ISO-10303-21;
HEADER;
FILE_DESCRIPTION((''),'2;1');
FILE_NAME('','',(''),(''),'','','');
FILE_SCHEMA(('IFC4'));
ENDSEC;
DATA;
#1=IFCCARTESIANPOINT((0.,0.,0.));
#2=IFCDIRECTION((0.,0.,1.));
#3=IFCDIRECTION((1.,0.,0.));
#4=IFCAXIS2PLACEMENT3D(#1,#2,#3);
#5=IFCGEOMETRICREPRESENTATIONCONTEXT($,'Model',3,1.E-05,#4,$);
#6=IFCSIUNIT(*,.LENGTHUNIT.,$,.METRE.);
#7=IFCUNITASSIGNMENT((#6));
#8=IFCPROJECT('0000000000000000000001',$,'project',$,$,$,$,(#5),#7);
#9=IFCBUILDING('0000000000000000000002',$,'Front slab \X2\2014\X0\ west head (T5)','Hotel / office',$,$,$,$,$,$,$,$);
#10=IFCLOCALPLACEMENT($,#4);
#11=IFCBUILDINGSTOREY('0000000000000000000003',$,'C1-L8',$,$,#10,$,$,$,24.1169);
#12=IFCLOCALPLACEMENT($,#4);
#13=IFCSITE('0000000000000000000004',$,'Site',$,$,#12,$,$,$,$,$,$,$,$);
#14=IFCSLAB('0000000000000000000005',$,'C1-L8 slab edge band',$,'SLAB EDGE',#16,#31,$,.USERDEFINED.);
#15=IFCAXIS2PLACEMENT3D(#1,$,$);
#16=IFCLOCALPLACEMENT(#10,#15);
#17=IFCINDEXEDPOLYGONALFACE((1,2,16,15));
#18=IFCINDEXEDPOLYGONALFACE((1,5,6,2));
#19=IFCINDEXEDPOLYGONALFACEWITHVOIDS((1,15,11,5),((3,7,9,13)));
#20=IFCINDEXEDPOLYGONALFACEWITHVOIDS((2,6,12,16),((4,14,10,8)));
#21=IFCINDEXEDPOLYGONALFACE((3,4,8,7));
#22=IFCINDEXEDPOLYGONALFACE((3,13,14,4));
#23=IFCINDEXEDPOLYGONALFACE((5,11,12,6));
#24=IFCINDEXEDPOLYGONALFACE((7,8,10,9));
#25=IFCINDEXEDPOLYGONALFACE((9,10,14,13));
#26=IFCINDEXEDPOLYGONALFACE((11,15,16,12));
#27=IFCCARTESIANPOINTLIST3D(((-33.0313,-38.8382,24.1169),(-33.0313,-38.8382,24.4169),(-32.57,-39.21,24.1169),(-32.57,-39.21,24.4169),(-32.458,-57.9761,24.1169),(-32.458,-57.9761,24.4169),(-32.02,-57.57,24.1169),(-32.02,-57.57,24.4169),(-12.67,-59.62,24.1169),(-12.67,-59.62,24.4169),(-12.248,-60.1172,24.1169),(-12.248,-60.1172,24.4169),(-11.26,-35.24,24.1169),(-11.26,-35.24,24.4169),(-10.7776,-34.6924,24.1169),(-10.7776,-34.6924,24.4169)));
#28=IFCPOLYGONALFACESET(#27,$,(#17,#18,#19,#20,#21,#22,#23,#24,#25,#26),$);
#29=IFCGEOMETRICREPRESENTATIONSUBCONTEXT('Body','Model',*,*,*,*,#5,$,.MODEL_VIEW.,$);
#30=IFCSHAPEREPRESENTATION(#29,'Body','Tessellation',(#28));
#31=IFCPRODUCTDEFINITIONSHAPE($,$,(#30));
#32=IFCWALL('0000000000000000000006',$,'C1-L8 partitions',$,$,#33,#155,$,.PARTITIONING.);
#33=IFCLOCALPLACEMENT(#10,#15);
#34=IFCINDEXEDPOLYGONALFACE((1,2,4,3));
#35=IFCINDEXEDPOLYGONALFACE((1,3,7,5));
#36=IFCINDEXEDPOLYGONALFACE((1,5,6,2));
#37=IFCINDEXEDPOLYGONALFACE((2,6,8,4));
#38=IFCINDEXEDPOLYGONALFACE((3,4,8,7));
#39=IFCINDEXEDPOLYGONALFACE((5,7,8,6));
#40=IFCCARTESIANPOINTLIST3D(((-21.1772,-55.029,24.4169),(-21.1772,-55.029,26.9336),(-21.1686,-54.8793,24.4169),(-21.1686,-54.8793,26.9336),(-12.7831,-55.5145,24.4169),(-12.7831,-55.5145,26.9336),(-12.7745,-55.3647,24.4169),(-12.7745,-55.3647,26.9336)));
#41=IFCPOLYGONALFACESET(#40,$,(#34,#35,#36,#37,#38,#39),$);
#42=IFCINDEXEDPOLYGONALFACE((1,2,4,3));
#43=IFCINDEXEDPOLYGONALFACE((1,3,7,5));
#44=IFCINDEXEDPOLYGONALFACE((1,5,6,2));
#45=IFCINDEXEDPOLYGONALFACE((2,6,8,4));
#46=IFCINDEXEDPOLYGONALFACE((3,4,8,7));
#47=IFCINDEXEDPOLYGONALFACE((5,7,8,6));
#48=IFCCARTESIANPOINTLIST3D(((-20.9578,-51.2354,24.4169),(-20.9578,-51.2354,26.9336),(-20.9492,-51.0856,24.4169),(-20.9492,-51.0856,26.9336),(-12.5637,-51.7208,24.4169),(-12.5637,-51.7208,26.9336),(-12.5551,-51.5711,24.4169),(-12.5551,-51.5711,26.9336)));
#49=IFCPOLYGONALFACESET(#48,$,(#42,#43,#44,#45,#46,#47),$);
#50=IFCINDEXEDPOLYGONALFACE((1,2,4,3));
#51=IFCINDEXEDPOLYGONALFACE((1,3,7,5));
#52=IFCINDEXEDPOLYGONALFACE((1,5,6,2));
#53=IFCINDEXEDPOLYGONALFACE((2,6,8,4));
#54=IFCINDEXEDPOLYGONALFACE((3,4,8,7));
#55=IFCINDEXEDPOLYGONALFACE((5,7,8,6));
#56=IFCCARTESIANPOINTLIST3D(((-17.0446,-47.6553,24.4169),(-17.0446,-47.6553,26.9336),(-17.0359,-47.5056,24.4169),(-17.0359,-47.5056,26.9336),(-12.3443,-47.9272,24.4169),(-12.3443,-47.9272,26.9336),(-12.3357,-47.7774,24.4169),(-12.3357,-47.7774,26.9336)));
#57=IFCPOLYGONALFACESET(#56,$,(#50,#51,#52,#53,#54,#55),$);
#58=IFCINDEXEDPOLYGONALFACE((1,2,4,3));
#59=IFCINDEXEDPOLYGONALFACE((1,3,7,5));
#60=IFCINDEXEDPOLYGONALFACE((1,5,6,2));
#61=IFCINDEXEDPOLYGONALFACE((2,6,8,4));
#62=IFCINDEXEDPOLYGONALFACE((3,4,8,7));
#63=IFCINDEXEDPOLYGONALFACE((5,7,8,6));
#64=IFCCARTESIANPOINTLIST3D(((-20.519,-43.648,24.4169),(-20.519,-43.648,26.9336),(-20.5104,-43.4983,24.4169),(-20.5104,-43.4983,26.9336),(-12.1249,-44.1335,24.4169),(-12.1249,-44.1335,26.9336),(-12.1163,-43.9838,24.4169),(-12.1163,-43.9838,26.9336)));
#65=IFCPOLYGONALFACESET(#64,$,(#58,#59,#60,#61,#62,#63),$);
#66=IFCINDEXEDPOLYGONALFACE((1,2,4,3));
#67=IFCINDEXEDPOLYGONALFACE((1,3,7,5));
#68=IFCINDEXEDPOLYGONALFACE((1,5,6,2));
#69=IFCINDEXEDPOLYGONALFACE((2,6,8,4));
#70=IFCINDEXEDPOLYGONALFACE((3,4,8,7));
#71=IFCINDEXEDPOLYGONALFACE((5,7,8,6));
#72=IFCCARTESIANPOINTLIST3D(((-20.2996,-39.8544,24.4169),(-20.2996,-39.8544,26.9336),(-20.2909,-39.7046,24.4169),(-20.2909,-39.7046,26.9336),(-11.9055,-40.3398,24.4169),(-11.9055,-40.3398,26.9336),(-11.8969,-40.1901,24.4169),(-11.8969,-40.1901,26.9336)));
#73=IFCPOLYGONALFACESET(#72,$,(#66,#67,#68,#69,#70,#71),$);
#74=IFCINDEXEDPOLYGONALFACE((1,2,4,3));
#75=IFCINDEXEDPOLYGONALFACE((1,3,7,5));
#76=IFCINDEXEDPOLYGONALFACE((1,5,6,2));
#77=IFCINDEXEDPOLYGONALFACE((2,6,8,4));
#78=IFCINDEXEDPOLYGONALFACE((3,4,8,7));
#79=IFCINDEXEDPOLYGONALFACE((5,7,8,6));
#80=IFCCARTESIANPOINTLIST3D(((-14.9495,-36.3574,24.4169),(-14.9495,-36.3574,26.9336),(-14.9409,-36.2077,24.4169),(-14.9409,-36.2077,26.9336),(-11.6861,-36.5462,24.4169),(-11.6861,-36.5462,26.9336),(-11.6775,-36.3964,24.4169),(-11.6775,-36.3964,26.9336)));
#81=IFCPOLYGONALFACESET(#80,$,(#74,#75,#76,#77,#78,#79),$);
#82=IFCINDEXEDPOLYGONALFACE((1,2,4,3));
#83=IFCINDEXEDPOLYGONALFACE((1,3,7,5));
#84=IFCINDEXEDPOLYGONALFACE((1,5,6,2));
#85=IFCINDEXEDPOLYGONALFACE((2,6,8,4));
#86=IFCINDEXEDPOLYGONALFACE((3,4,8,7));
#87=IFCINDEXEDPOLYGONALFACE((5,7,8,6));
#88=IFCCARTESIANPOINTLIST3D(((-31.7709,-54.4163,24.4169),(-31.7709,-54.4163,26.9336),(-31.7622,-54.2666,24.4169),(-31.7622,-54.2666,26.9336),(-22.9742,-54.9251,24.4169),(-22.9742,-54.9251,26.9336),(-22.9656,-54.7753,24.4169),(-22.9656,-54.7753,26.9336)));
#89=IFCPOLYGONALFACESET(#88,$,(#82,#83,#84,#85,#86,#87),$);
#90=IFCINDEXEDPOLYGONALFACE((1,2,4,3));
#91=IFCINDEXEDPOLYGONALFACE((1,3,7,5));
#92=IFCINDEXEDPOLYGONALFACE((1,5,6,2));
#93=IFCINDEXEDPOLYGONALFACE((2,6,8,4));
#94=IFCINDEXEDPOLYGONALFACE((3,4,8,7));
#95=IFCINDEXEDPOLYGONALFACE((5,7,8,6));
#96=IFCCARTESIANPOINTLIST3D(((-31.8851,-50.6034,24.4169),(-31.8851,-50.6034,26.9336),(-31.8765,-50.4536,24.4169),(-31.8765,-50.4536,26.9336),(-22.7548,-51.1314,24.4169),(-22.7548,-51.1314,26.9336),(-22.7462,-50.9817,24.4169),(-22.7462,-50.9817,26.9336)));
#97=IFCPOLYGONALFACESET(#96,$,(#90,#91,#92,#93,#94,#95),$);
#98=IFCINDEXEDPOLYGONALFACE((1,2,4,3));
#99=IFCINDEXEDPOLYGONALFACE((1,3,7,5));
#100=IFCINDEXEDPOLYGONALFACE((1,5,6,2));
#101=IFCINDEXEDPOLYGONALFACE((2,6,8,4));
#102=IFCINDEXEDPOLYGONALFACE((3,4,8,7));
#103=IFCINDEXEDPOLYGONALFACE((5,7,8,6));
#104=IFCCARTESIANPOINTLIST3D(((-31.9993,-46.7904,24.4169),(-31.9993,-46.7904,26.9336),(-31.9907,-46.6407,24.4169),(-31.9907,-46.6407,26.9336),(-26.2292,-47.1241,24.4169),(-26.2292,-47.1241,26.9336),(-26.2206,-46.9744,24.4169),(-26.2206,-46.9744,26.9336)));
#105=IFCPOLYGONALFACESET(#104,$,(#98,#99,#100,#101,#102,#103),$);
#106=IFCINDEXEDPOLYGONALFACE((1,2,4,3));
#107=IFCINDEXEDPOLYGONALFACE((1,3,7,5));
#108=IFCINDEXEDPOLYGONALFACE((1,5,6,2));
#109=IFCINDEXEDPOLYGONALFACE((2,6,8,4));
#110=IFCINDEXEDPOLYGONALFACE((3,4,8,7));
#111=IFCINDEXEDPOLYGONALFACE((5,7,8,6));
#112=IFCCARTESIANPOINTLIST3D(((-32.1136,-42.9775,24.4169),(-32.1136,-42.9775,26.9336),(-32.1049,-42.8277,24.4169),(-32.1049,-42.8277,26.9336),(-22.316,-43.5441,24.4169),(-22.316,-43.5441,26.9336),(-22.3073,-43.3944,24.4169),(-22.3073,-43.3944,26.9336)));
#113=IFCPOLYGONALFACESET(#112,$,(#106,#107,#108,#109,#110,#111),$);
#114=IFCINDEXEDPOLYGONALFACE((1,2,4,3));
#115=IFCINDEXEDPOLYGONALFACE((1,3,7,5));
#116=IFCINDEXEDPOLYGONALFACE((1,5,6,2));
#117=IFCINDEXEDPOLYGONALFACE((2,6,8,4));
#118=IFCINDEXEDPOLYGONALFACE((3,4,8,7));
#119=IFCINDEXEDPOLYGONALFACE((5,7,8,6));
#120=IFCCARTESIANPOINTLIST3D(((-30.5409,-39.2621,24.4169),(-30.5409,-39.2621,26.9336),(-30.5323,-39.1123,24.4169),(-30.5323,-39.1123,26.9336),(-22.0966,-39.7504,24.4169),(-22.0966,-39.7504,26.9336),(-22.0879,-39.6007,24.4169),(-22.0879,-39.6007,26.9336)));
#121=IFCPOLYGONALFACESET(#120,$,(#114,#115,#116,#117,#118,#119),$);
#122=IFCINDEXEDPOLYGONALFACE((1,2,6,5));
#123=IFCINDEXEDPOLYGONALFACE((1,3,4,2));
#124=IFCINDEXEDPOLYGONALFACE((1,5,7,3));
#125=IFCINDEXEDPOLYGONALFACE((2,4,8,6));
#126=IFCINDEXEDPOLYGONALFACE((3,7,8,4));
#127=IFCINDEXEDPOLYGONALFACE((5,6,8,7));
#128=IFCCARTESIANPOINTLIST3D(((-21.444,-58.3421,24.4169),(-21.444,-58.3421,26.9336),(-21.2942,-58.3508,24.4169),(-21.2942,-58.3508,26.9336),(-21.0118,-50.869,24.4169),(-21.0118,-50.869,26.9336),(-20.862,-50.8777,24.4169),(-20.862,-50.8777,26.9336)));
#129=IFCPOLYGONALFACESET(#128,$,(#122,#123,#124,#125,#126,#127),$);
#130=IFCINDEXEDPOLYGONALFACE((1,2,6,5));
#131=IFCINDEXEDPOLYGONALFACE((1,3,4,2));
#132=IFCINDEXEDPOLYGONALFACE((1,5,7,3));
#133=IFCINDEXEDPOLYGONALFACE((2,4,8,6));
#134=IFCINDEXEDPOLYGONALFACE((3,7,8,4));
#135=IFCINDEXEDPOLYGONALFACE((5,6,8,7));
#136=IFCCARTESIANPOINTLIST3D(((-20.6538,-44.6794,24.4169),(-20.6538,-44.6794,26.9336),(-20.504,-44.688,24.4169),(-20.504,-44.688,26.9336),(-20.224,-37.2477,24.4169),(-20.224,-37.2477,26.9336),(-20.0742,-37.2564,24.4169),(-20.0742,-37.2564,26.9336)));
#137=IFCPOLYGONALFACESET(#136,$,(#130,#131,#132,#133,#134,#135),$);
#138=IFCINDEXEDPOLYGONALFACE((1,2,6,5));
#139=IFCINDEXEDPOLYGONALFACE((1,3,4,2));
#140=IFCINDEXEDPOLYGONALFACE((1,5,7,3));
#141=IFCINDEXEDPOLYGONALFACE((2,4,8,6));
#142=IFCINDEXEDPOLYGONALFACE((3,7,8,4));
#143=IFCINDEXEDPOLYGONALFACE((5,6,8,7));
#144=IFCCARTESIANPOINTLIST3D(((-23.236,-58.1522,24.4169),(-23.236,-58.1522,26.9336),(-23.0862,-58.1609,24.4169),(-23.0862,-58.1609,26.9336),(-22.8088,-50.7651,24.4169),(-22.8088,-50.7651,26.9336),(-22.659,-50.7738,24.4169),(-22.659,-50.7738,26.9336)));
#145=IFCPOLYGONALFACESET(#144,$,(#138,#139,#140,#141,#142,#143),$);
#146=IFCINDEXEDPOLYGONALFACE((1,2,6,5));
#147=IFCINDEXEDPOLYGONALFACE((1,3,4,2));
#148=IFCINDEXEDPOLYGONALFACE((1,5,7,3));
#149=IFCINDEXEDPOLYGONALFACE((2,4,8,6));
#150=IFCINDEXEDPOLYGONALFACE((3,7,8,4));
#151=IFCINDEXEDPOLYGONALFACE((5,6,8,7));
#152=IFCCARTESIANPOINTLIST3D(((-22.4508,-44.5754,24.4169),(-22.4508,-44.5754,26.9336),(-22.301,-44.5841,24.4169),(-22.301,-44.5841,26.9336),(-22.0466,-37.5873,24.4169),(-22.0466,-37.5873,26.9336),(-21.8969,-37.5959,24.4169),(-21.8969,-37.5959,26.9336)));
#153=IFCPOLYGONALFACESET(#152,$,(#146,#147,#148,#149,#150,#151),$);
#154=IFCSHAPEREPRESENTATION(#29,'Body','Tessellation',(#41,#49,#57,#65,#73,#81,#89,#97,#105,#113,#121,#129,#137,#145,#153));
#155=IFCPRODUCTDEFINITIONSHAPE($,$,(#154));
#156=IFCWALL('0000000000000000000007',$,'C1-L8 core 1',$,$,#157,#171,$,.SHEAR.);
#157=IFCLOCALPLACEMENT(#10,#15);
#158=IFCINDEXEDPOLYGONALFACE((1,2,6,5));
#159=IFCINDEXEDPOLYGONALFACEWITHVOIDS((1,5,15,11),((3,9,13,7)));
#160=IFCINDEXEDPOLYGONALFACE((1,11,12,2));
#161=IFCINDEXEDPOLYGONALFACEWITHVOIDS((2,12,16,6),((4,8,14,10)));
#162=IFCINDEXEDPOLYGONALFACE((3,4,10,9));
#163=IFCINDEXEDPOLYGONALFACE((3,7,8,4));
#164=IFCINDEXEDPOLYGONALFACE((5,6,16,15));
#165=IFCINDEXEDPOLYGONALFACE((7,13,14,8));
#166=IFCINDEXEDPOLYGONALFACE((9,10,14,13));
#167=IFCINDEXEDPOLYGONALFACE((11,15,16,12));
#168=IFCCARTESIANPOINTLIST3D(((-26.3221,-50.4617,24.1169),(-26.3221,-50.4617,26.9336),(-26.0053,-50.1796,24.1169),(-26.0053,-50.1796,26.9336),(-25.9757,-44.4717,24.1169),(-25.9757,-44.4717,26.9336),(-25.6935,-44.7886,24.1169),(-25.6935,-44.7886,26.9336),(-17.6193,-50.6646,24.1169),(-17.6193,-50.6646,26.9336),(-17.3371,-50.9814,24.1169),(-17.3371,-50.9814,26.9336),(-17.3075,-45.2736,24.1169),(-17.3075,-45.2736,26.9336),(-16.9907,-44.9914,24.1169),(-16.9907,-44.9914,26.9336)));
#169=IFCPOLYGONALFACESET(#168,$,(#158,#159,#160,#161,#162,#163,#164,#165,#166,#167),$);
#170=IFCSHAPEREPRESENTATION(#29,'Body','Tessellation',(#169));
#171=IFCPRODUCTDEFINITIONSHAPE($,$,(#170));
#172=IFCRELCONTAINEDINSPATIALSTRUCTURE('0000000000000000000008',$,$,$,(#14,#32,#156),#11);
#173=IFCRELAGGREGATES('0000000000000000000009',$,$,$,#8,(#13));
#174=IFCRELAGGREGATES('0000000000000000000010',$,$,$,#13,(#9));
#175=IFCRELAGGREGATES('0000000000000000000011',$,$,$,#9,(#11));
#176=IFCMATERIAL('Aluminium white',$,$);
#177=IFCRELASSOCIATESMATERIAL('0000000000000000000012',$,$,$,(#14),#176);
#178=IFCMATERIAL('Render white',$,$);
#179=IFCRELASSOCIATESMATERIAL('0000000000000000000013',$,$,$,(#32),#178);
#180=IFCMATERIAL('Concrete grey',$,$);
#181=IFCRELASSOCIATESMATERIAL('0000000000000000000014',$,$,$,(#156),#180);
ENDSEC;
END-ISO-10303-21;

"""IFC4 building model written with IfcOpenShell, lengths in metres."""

from ifc_helpers import new_model, si_unit, frame, origin_with_axes, place, context, subcontext, project, spatial, polyline, outline, extrude, material, element, save


model = new_model("IFC4")

# Units and contexts
model_context = context("Model", 3, precision=1e-05, world=origin_with_axes())
body_context = subcontext(model_context, "Body", "Model", "MODEL_VIEW")
ifc_project = project(units=[si_unit("LENGTHUNIT", "METRE")], contexts=[model_context])

# Site, building, storey
site_placement = place(None, origin_with_axes())
site = spatial("IfcSite", under=ifc_project, at=site_placement, Name="Site")
building = spatial("IfcBuilding", under=site, Name="Front slab — west head (T5)", Description="Hotel / office")
storey_placement = place(None, origin_with_axes())
storey = spatial("IfcBuildingStorey", under=building, at=storey_placement, Name="C1-L8", Elevation=24.1169)

# Shared definitions
ifc_material_1 = material(Name="Aluminium white")

# Slab
slab_placement = place(storey_placement, origin_with_axes())
element("IfcSlab", 1, at=slab_placement, inside=storey, material=ifc_material_1, Name="C1-L8 slab edge band", ObjectType="SLAB EDGE", PredefinedType="USERDEFINED", context=body_context, shape_type="SweptSolid", body=[
    extrude(outline(polyline([(-33.0313, -38.8382), (-32.458, -57.9761), (-12.248, -60.1172), (-10.7776, -34.6924), (-33.0313, -38.8382)]), holes=[polyline([(-32.57, -39.21), (-32.02, -57.57), (-12.67, -59.62), (-11.26, -35.24), (-32.57, -39.21)])]), frame((0.0, 0.0, 24.1169), z_axis=(0.0, 0.0, 1.0), x_axis=(1.0, 0.0, 0.0)), (0.0, 0.0, 1.0), 0.3),
])

# Walls
ifc_material_2 = material(Name="Render white")
wall_1_placement = place(storey_placement, origin_with_axes())
element("IfcWall", 2, at=wall_1_placement, inside=storey, material=ifc_material_2, Name="C1-L8 partitions", PredefinedType="PARTITIONING", context=body_context, shape_type="SweptSolid", body=[
    extrude(outline(polyline([(-12.7745, -55.3647), (-21.1686, -54.8793), (-21.1772, -55.029), (-12.7831, -55.5145), (-12.7745, -55.3647)])), frame((0.0, 0.0, 24.4169), z_axis=(0.0, 0.0, 1.0), x_axis=(1.0, 0.0, 0.0)), (0.0, 0.0, 1.0), 2.5167),
    extrude(outline(polyline([(-12.5551, -51.5711), (-20.9492, -51.0856), (-20.9578, -51.2354), (-12.5637, -51.7208), (-12.5551, -51.5711)])), frame((0.0, 0.0, 24.4169), z_axis=(0.0, 0.0, 1.0), x_axis=(1.0, 0.0, 0.0)), (0.0, 0.0, 1.0), 2.5167),
    extrude(outline(polyline([(-12.3357, -47.7774), (-17.0359, -47.5056), (-17.0446, -47.6553), (-12.3443, -47.9272), (-12.3357, -47.7774)])), frame((0.0, 0.0, 24.4169), z_axis=(0.0, 0.0, 1.0), x_axis=(1.0, 0.0, 0.0)), (0.0, 0.0, 1.0), 2.5167),
    extrude(outline(polyline([(-12.1163, -43.9838), (-20.5104, -43.4983), (-20.519, -43.648), (-12.1249, -44.1335), (-12.1163, -43.9838)])), frame((0.0, 0.0, 24.4169), z_axis=(0.0, 0.0, 1.0), x_axis=(1.0, 0.0, 0.0)), (0.0, 0.0, 1.0), 2.5167),
    extrude(outline(polyline([(-11.8969, -40.1901), (-20.2909, -39.7046), (-20.2996, -39.8544), (-11.9055, -40.3398), (-11.8969, -40.1901)])), frame((0.0, 0.0, 24.4169), z_axis=(0.0, 0.0, 1.0), x_axis=(1.0, 0.0, 0.0)), (0.0, 0.0, 1.0), 2.5167),
    extrude(outline(polyline([(-11.6775, -36.3964), (-14.9409, -36.2077), (-14.9495, -36.3574), (-11.6861, -36.5462), (-11.6775, -36.3964)])), frame((0.0, 0.0, 24.4169), z_axis=(0.0, 0.0, 1.0), x_axis=(1.0, 0.0, 0.0)), (0.0, 0.0, 1.0), 2.5167),
    extrude(outline(polyline([(-22.9656, -54.7753), (-31.7622, -54.2666), (-31.7709, -54.4163), (-22.9742, -54.9251), (-22.9656, -54.7753)])), frame((0.0, 0.0, 24.4169), z_axis=(0.0, 0.0, 1.0), x_axis=(1.0, 0.0, 0.0)), (0.0, 0.0, 1.0), 2.5167),
    extrude(outline(polyline([(-22.7462, -50.9817), (-31.8765, -50.4536), (-31.8851, -50.6034), (-22.7548, -51.1314), (-22.7462, -50.9817)])), frame((0.0, 0.0, 24.4169), z_axis=(0.0, 0.0, 1.0), x_axis=(1.0, 0.0, 0.0)), (0.0, 0.0, 1.0), 2.5167),
    extrude(outline(polyline([(-26.2206, -46.9744), (-31.9907, -46.6407), (-31.9993, -46.7904), (-26.2292, -47.1241), (-26.2206, -46.9744)])), frame((0.0, 0.0, 24.4169), z_axis=(0.0, 0.0, 1.0), x_axis=(1.0, 0.0, 0.0)), (0.0, 0.0, 1.0), 2.5167),
    extrude(outline(polyline([(-22.3073, -43.3944), (-32.1049, -42.8277), (-32.1136, -42.9775), (-22.316, -43.5441), (-22.3073, -43.3944)])), frame((0.0, 0.0, 24.4169), z_axis=(0.0, 0.0, 1.0), x_axis=(1.0, 0.0, 0.0)), (0.0, 0.0, 1.0), 2.5167),
    extrude(outline(polyline([(-22.0879, -39.6007), (-30.5323, -39.1123), (-30.5409, -39.2621), (-22.0966, -39.7504), (-22.0879, -39.6007)])), frame((0.0, 0.0, 24.4169), z_axis=(0.0, 0.0, 1.0), x_axis=(1.0, 0.0, 0.0)), (0.0, 0.0, 1.0), 2.5167),
    extrude(outline(polyline([(-21.2942, -58.3508), (-20.862, -50.8777), (-21.0118, -50.869), (-21.444, -58.3421), (-21.2942, -58.3508)])), frame((0.0, 0.0, 24.4169), z_axis=(0.0, 0.0, 1.0), x_axis=(1.0, 0.0, 0.0)), (0.0, 0.0, 1.0), 2.5167),
    extrude(outline(polyline([(-20.504, -44.688), (-20.0742, -37.2564), (-20.224, -37.2477), (-20.6538, -44.6794), (-20.504, -44.688)])), frame((0.0, 0.0, 24.4169), z_axis=(0.0, 0.0, 1.0), x_axis=(1.0, 0.0, 0.0)), (0.0, 0.0, 1.0), 2.5167),
    extrude(outline(polyline([(-23.0862, -58.1609), (-22.659, -50.7738), (-22.8088, -50.7651), (-23.236, -58.1522), (-23.0862, -58.1609)])), frame((0.0, 0.0, 24.4169), z_axis=(0.0, 0.0, 1.0), x_axis=(1.0, 0.0, 0.0)), (0.0, 0.0, 1.0), 2.5167),
    extrude(outline(polyline([(-22.301, -44.5841), (-21.8969, -37.5959), (-22.0466, -37.5873), (-22.4508, -44.5754), (-22.301, -44.5841)])), frame((0.0, 0.0, 24.4169), z_axis=(0.0, 0.0, 1.0), x_axis=(1.0, 0.0, 0.0)), (0.0, 0.0, 1.0), 2.5167),
])
ifc_material_3 = material(Name="Concrete grey")
wall_2_placement = place(storey_placement, origin_with_axes())
element("IfcWall", 3, at=wall_2_placement, inside=storey, material=ifc_material_3, Name="C1-L8 core 1", PredefinedType="SHEAR", context=body_context, shape_type="SweptSolid", body=[
    extrude(outline(polyline([(-17.3371, -50.9814), (-16.9907, -44.9914), (-25.9757, -44.4717), (-26.3221, -50.4617), (-17.3371, -50.9814)]), holes=[polyline([(-17.6193, -50.6646), (-17.3075, -45.2736), (-25.6935, -44.7886), (-26.0053, -50.1796), (-17.6193, -50.6646)])]), frame((0.0, 0.0, 24.1169), z_axis=(0.0, 0.0, 1.0), x_axis=(1.0, 0.0, 0.0)), (0.0, 0.0, 1.0), 2.8167),
])

save(model, "model.ifc")
